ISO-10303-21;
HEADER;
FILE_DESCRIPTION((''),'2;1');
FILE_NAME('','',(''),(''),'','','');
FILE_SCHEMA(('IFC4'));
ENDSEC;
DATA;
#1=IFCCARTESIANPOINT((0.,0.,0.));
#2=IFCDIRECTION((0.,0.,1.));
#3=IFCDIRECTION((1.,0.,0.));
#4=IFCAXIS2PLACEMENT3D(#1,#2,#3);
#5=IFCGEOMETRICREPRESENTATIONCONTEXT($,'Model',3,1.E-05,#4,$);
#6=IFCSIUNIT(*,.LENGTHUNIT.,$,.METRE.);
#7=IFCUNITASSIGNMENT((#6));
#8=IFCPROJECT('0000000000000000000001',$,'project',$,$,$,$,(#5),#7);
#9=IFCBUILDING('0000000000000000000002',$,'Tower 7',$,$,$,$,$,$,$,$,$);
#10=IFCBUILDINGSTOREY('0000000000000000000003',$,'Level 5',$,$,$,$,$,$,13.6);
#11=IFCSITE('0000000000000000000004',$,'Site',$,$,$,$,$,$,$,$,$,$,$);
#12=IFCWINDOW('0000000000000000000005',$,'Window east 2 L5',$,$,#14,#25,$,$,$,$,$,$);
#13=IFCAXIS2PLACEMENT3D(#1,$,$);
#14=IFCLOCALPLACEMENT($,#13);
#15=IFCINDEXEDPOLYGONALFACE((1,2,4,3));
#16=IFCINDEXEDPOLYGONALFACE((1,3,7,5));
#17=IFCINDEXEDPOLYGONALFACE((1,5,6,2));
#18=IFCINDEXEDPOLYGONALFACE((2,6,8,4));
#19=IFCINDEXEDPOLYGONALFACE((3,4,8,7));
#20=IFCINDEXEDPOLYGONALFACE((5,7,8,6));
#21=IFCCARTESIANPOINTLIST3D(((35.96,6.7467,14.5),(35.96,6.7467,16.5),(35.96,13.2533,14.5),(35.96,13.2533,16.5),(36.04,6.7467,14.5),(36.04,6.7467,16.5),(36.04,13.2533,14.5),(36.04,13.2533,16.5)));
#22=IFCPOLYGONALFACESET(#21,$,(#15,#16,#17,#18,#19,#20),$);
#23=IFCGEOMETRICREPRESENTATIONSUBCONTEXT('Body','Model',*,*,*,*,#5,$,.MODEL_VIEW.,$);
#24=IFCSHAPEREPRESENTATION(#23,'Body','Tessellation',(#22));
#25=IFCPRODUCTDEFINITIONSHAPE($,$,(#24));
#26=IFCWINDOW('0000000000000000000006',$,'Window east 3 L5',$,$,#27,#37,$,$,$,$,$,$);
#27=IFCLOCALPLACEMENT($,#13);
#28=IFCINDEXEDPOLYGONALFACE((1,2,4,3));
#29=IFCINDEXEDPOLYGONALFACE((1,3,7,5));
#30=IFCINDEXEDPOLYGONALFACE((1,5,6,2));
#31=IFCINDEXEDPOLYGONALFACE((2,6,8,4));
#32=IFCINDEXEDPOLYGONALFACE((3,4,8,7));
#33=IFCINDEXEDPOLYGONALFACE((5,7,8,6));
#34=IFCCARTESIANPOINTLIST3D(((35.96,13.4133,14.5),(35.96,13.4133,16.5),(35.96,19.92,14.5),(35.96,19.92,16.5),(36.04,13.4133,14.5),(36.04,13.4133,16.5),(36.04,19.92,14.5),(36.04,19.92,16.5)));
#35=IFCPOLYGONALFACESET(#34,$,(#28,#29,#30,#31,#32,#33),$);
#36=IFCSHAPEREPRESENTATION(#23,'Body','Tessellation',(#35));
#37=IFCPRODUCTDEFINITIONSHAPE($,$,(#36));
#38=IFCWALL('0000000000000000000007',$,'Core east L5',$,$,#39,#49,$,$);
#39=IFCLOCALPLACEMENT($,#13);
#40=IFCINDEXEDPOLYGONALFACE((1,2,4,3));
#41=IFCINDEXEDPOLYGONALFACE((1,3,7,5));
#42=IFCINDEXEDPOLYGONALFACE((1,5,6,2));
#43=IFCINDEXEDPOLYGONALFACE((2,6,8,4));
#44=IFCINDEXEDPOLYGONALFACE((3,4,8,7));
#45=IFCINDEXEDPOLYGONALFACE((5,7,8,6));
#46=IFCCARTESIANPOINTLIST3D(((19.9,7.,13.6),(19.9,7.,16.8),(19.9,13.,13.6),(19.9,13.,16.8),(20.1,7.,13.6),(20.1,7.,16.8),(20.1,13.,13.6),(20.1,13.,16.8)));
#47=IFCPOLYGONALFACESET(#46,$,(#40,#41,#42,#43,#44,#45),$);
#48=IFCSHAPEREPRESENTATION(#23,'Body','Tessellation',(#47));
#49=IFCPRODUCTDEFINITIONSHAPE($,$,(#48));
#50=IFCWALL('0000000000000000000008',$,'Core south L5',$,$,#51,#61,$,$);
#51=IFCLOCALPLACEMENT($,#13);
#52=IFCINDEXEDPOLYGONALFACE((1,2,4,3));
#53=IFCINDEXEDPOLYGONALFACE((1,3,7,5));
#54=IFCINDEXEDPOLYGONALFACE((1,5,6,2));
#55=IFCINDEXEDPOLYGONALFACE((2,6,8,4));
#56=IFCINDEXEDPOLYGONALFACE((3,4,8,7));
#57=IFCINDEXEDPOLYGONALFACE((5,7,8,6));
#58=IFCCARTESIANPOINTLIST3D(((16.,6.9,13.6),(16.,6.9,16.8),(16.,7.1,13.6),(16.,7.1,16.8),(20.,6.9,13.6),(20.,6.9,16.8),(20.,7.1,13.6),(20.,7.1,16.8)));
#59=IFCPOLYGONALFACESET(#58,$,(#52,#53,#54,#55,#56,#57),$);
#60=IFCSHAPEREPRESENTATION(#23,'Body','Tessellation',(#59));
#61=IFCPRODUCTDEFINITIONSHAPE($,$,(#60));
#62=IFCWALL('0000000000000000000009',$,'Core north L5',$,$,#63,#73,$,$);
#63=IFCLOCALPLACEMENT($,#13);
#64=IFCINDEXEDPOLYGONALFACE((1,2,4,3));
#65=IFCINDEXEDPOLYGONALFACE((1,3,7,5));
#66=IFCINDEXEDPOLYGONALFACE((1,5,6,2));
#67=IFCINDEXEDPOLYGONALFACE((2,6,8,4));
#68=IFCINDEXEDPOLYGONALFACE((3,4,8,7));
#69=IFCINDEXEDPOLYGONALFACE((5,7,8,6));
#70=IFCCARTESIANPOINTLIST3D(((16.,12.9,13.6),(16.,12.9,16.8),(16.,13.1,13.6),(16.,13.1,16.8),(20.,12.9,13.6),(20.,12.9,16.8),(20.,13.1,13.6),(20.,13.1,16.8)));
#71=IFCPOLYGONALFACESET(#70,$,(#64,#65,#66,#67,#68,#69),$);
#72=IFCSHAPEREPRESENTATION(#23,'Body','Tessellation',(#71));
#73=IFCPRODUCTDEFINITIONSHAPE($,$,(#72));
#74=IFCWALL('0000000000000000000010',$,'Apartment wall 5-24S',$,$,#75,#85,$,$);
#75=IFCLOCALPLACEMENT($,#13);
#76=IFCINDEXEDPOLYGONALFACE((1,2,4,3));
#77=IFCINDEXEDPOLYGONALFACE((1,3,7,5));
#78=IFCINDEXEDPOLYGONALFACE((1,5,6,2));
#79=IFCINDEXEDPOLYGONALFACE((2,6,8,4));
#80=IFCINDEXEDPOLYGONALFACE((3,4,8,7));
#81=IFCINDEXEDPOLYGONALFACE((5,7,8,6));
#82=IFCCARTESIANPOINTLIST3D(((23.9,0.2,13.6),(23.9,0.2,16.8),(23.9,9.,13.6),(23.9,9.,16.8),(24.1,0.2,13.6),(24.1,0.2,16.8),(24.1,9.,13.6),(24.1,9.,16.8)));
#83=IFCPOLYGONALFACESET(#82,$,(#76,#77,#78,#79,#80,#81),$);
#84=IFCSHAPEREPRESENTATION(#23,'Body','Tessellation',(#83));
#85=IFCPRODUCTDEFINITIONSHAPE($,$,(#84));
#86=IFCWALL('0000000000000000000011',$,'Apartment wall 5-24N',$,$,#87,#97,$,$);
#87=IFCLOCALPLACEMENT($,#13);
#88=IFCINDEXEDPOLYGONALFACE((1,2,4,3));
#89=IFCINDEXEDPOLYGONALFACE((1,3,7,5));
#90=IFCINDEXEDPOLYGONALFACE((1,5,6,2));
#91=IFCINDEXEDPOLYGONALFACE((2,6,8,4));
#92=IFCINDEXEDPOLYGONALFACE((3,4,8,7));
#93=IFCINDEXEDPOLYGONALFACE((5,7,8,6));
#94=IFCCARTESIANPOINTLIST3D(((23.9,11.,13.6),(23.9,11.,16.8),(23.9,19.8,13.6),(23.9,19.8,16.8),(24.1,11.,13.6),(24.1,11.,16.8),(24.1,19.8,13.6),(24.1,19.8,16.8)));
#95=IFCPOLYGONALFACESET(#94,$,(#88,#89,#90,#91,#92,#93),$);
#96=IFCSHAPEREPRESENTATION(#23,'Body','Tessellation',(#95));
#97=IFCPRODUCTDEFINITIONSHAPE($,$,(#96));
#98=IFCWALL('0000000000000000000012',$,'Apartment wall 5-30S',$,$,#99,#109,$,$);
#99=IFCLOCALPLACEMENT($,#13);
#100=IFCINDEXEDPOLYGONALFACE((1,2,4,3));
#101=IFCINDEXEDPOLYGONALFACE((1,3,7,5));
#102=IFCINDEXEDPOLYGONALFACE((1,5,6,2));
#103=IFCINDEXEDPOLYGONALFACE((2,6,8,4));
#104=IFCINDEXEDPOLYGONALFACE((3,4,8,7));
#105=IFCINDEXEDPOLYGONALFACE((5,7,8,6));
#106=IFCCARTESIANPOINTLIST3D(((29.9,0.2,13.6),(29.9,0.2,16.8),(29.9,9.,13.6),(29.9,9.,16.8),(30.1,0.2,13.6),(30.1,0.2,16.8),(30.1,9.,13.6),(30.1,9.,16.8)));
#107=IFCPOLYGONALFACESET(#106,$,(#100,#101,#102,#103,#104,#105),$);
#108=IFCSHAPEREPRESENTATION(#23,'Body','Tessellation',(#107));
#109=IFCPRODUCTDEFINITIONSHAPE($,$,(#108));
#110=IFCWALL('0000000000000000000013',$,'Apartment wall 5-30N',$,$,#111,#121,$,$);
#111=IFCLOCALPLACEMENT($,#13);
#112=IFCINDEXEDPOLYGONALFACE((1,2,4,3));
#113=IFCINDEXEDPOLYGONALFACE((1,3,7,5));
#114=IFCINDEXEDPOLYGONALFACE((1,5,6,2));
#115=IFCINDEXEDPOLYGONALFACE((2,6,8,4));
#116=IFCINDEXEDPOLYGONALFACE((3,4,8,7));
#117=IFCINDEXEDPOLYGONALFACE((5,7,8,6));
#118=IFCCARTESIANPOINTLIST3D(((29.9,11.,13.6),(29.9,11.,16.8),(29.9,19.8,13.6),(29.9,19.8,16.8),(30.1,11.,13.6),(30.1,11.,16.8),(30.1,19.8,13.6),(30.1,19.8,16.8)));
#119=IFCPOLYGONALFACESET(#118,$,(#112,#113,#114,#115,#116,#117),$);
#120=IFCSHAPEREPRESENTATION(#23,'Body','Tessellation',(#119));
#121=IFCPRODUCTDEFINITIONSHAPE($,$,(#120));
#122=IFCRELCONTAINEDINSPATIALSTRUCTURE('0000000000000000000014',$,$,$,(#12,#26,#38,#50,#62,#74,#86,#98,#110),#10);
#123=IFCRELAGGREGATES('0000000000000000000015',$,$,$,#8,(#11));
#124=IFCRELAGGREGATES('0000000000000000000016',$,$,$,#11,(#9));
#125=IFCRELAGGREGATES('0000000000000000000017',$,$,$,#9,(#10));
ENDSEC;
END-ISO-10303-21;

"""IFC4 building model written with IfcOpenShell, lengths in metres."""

from ifc_helpers import new_model, si_unit, frame, origin, origin_with_axes, origin_2d, place, context, subcontext, project, spatial, rectangle, extrude, element, save


model = new_model("IFC4")

# Units and contexts
model_context = context("Model", 3, precision=1e-05, world=origin_with_axes())
body_context = subcontext(model_context, "Body", "Model", "MODEL_VIEW")
ifc_project = project(units=[si_unit("LENGTHUNIT", "METRE")], contexts=[model_context])

# Site, building, storey
site = spatial("IfcSite", under=ifc_project, Name="Site")
building = spatial("IfcBuilding", under=site, Name="Tower 7")
storey = spatial("IfcBuildingStorey", under=building, Name="Level 5", Elevation=13.6)

# Windows
for number, where, z_axis, x_axis, name in (
    (1, (36.0, 10.0, 14.5), (0.0, 0.0, 1.0), (1.0, 0.0, 0.0), "Window east 2 L5"),
):
    element("IfcWindow", number, at=place(None, frame(where, z_axis=z_axis, x_axis=x_axis)), inside=storey, Name=name, context=body_context, shape_type="SweptSolid", body=[
        extrude(rectangle(XDim=0.08, YDim=6.5067, at=origin_2d()), origin(), (0.0, 0.0, 1.0), 2.0),
    ])
window_placement = place(None, frame((36.0, 16.6667, 14.5), z_axis=(0.0, 0.0, 1.0), x_axis=(1.0, 0.0, 0.0)))
element("IfcWindow", 2, at=window_placement, inside=storey, Name="Window east 3 L5", context=body_context, shape_type="SweptSolid", body=[
    extrude(rectangle(XDim=0.08, YDim=6.5067, at=origin_2d()), origin(), (0.0, 0.0, 1.0), 2.0),
])

# Walls
wall_1_placement = place(None, frame((20.0, 10.0, 13.6), z_axis=(0.0, 0.0, 1.0), x_axis=(1.0, 0.0, 0.0)))
element("IfcWall", 3, at=wall_1_placement, inside=storey, Name="Core east L5", context=body_context, shape_type="SweptSolid", body=[
    extrude(rectangle(XDim=0.2, YDim=6.0, at=origin_2d()), origin(), (0.0, 0.0, 1.0), 3.2),
])
for number, where, z_axis, x_axis, name in (
    (4, (18.0, 7.0, 13.6), (0.0, 0.0, 1.0), (1.0, 0.0, 0.0), "Core south L5"),
    (5, (18.0, 13.0, 13.6), (0.0, 0.0, 1.0), (1.0, 0.0, 0.0), "Core north L5"),
):
    element("IfcWall", number, at=place(None, frame(where, z_axis=z_axis, x_axis=x_axis)), inside=storey, Name=name, context=body_context, shape_type="SweptSolid", body=[
        extrude(rectangle(XDim=4.0, YDim=0.2, at=origin_2d()), origin(), (0.0, 0.0, 1.0), 3.2),
    ])
for number, where, z_axis, x_axis, name in (
    (6, (24.0, 4.6, 13.6), (0.0, 0.0, 1.0), (1.0, 0.0, 0.0), "Apartment wall 5-24S"),
    (7, (24.0, 15.4, 13.6), (0.0, 0.0, 1.0), (1.0, 0.0, 0.0), "Apartment wall 5-24N"),
    (8, (30.0, 4.6, 13.6), (0.0, 0.0, 1.0), (1.0, 0.0, 0.0), "Apartment wall 5-30S"),
    (9, (30.0, 15.4, 13.6), (0.0, 0.0, 1.0), (1.0, 0.0, 0.0), "Apartment wall 5-30N"),
):
    element("IfcWall", number, at=place(None, frame(where, z_axis=z_axis, x_axis=x_axis)), inside=storey, Name=name, context=body_context, shape_type="SweptSolid", body=[
        extrude(rectangle(XDim=0.2, YDim=8.8, at=origin_2d()), origin(), (0.0, 0.0, 1.0), 3.2),
    ])

save(model, "model.ifc")
